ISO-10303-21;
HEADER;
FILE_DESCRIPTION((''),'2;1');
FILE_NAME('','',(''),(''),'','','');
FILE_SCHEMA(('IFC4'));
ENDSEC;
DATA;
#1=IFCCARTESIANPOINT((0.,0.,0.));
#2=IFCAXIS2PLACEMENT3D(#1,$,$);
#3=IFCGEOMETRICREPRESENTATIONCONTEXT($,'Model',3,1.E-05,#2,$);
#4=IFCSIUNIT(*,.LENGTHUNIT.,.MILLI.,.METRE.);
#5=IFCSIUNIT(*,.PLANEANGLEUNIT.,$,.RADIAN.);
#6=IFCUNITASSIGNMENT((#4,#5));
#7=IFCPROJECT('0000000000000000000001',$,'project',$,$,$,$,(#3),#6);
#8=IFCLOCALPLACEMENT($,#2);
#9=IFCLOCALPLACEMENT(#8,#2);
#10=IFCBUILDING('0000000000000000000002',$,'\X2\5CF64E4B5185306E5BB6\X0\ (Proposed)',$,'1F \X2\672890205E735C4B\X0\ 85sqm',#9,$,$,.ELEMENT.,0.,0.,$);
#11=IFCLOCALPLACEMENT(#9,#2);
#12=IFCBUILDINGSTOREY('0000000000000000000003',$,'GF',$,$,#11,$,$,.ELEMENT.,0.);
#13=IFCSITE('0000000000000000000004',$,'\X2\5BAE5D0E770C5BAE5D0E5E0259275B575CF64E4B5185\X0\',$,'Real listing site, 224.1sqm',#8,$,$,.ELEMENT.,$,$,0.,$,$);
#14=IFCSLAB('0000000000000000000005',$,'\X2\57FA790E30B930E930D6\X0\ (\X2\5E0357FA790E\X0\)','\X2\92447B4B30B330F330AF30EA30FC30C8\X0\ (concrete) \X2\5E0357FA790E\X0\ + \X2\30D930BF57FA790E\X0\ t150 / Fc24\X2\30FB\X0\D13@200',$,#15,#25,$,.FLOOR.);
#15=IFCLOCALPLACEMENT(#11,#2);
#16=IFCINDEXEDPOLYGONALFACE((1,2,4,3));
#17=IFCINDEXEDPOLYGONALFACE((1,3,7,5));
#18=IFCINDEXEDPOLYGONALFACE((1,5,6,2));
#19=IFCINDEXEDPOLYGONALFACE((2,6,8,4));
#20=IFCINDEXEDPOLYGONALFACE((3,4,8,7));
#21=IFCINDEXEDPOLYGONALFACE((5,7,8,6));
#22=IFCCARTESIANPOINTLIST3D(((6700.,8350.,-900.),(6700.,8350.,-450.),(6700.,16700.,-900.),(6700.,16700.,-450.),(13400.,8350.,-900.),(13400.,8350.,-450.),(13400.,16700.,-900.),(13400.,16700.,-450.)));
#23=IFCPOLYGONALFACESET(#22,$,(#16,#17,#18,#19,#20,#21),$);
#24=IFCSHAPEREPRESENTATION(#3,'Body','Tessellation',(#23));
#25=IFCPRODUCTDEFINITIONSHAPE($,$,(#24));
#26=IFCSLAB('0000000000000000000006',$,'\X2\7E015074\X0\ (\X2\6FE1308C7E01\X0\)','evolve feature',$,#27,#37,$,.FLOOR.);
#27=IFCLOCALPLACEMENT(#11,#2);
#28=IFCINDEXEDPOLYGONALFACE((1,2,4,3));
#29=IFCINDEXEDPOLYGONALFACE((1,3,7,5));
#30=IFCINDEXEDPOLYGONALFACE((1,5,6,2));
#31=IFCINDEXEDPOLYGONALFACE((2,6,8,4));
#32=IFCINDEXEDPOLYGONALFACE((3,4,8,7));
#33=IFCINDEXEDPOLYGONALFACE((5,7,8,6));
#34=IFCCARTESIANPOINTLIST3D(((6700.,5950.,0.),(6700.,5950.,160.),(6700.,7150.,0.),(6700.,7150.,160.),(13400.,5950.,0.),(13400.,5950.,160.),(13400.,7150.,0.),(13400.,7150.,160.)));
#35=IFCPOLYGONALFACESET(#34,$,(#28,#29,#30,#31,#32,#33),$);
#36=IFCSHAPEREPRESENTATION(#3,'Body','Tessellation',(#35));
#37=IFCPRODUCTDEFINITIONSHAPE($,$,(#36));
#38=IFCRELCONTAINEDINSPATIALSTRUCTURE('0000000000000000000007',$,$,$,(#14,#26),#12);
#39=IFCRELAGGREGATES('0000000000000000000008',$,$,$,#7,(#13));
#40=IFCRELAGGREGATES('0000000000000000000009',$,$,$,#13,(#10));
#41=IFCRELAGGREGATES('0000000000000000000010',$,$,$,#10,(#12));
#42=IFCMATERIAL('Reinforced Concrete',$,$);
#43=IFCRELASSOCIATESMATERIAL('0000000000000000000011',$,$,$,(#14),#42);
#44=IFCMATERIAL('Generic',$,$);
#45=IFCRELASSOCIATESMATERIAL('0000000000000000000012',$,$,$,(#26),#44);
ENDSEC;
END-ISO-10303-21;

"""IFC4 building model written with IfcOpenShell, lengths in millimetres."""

from ifc_helpers import new_model, si_unit, frame, frame_2d, origin, place, context, project, spatial, rectangle, extrude, material, element, save


model = new_model("IFC4")

# Units and contexts
model_context = context("Model", 3, precision=1e-05, world=origin())
ifc_project = project(units=[si_unit("LENGTHUNIT", "METRE", prefix="MILLI"), si_unit("PLANEANGLEUNIT", "RADIAN")], contexts=[model_context])

# Site, building, storey
site_placement = place(None, origin())
site = spatial("IfcSite", under=ifc_project, at=site_placement, Name="宮崎県宮崎市大字島之内", ObjectType="Real listing site, 224.1sqm", CompositionType="ELEMENT", RefElevation=0.0)
building_placement = place(site_placement, origin())
building = spatial("IfcBuilding", under=site, at=building_placement, Name="島之内の家 (Proposed)", ObjectType="1F 木造平屋 85sqm", CompositionType="ELEMENT", ElevationOfRefHeight=0.0, ElevationOfTerrain=0.0)
storey_placement = place(building_placement, origin())
storey = spatial("IfcBuildingStorey", under=building, at=storey_placement, Name="GF", CompositionType="ELEMENT", Elevation=0.0)

# Slabs
ifc_material_1 = material(Name="Reinforced Concrete")
slab_1_placement = place(storey_placement, frame((3350.0, 4175.0, -450.0)))
element("IfcSlab", 1, at=slab_1_placement, inside=storey, material=ifc_material_1, Name="基礎スラブ (布基礎)", Description="鉄筋コンクリート (concrete) 布基礎 + ベタ基礎 t150 / Fc24・D13@200", PredefinedType="FLOOR", context=model_context, shape_type="SweptSolid", body=[
    extrude(rectangle(XDim=6700.0, YDim=8350.0, at=frame_2d((3350.0, 4175.0))), frame((3350.0, 4175.0, -450.0)), (0.0, 0.0, 1.0), 450.0),
])
ifc_material_2 = material(Name="Generic")
slab_2_placement = place(storey_placement, frame((3350.0, 2975.0, 0.0)))
element("IfcSlab", 2, at=slab_2_placement, inside=storey, material=ifc_material_2, Name="縁側 (濡れ縁)", Description="evolve feature", PredefinedType="FLOOR", context=model_context, shape_type="SweptSolid", body=[
    extrude(rectangle(XDim=6700.0, YDim=1200.0, at=frame_2d((3350.0, 600.0))), frame((3350.0, 2975.0, 0.0)), (0.0, 0.0, 1.0), 160.0),
])

save(model, "model.ifc")
